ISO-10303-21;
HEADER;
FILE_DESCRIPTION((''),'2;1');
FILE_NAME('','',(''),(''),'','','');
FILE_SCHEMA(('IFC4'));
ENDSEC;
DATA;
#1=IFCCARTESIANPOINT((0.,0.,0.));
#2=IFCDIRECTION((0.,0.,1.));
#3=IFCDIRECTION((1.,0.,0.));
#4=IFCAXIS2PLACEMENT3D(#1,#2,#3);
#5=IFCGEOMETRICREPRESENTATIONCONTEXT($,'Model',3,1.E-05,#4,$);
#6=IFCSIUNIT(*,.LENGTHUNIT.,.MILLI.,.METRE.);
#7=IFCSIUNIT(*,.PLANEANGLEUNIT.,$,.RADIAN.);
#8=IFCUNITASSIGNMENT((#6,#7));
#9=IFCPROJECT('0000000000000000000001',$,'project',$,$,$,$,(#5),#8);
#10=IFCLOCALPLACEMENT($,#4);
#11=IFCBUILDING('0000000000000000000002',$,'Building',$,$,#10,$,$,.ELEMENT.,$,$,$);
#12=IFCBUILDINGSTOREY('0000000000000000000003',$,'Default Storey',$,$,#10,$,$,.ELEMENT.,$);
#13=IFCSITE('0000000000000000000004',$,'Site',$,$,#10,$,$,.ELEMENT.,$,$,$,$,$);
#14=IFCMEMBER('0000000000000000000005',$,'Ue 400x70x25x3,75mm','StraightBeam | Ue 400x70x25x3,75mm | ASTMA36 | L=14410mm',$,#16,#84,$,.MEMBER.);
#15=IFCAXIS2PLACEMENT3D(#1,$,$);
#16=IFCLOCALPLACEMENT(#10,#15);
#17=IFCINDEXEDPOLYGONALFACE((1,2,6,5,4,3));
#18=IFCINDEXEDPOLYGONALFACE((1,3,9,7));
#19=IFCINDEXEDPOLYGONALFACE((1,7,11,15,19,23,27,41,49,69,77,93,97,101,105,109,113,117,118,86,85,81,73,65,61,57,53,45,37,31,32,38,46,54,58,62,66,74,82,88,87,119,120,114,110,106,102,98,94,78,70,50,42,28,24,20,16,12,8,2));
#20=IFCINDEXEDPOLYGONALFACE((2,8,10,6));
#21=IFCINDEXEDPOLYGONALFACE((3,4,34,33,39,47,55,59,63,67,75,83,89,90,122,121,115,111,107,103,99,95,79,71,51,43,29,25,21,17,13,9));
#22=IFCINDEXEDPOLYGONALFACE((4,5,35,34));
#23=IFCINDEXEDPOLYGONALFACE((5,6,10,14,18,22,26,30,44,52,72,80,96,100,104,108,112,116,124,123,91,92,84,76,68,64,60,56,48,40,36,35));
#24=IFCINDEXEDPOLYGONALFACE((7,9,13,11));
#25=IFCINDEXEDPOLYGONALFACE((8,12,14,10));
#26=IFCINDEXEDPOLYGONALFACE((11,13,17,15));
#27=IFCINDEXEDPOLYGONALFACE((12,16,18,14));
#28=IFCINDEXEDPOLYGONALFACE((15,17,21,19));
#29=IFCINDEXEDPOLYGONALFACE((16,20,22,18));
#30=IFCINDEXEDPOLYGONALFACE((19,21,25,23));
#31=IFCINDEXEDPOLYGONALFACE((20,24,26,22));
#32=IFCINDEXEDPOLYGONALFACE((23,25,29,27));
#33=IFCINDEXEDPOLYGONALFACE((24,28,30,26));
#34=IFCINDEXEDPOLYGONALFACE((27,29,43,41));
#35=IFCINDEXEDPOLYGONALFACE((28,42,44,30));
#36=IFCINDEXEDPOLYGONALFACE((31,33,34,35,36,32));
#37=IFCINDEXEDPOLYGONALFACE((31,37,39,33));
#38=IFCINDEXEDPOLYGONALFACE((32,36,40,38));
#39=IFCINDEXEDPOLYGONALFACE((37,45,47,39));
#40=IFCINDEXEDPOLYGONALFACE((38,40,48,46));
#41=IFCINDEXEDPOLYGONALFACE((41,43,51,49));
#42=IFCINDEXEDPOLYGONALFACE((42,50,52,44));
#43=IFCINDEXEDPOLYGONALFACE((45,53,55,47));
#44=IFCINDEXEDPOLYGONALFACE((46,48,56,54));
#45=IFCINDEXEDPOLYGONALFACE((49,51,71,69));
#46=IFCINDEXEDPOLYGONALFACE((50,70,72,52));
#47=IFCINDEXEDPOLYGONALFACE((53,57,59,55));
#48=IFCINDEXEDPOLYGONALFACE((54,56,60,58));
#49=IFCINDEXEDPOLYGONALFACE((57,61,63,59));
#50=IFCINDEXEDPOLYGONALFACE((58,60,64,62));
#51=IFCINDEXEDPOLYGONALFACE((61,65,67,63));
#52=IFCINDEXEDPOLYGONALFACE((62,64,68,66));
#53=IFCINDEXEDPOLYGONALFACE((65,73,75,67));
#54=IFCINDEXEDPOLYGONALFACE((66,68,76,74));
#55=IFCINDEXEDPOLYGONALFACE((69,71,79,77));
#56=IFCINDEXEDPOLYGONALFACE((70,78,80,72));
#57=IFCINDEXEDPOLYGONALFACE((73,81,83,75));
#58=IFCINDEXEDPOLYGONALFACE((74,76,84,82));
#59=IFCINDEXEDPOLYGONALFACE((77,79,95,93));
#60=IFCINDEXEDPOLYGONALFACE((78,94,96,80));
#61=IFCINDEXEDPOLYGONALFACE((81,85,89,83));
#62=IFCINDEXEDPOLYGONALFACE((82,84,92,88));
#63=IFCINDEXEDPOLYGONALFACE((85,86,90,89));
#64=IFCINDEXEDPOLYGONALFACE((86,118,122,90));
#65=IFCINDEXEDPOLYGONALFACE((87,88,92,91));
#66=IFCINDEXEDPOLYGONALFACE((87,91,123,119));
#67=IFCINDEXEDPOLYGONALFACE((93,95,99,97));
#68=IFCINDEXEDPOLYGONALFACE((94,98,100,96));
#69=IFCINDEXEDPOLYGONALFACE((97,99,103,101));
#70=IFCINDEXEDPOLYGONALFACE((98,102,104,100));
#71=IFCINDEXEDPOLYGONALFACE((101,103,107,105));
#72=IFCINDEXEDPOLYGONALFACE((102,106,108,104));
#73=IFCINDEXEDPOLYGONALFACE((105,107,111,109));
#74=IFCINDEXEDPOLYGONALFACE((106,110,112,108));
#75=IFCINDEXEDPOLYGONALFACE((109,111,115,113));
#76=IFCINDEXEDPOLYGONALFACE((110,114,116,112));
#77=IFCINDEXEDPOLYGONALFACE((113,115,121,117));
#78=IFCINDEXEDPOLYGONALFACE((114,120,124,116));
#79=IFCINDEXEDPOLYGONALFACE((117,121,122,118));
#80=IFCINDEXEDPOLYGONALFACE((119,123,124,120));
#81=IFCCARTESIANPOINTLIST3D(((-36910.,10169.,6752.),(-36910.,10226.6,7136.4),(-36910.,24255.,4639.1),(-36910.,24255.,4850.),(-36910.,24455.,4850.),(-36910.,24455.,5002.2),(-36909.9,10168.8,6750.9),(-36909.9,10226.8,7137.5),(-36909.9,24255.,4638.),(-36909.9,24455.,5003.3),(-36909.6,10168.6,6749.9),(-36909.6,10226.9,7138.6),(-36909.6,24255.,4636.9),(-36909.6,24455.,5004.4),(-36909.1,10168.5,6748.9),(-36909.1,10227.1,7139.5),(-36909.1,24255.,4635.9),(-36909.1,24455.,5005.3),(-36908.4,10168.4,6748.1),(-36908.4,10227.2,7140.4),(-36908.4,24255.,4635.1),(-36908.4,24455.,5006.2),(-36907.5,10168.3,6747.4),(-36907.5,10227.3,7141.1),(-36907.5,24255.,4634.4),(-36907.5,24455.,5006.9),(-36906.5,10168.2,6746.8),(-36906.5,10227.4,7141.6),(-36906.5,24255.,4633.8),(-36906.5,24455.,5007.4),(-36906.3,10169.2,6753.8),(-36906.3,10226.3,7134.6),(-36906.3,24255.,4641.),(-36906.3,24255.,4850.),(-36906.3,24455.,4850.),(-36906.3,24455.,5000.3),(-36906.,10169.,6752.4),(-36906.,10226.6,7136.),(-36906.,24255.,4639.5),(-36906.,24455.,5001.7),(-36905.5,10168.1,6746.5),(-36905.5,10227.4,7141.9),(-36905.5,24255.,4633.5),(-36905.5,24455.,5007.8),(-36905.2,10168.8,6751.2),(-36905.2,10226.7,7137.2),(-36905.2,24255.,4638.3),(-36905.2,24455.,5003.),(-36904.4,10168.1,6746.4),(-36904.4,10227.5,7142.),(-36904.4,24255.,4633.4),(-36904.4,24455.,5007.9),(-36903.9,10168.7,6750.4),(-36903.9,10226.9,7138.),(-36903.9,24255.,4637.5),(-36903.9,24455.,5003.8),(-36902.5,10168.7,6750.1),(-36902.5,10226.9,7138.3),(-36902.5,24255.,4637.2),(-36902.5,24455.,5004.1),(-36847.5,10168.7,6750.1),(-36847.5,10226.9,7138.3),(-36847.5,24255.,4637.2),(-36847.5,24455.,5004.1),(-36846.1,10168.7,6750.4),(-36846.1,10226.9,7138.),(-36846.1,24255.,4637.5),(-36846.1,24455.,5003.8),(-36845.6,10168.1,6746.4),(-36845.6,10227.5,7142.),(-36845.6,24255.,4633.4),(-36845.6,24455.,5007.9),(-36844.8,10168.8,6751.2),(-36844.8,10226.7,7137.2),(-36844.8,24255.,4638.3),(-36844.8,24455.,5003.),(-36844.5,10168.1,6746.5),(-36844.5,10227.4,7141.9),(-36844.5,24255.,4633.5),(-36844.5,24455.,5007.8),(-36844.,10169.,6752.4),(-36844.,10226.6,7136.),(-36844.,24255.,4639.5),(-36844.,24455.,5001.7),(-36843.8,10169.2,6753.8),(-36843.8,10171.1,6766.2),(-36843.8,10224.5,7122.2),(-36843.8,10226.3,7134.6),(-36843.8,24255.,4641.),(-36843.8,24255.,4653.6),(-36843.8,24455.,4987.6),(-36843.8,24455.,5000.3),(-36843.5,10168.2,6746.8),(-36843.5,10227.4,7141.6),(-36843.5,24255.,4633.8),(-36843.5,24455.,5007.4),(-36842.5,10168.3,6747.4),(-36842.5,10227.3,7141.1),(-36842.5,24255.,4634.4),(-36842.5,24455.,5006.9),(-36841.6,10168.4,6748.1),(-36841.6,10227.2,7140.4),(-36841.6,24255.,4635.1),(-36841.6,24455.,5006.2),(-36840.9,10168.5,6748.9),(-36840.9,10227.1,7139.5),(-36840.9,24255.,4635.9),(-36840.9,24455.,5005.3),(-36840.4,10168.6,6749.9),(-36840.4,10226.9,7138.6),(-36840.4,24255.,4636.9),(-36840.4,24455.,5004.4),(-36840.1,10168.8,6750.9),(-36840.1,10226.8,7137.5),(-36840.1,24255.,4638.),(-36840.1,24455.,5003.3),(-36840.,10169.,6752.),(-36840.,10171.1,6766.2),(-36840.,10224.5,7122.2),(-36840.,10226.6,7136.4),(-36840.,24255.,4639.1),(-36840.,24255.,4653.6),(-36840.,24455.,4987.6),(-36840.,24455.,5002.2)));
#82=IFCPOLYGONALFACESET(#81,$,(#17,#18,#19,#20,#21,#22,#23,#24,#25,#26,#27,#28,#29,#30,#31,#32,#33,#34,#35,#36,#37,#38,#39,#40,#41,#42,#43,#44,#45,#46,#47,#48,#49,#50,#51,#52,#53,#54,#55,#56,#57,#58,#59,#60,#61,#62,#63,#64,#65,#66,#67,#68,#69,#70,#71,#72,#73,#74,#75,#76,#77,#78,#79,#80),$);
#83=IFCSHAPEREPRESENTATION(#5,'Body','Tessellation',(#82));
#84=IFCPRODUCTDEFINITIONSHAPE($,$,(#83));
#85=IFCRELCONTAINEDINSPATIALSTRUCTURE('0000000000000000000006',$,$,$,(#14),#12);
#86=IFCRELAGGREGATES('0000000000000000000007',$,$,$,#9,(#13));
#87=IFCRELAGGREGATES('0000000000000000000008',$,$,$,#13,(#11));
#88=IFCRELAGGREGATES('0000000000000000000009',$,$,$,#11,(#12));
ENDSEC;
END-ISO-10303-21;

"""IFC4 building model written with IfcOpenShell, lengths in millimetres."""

from ifc_helpers import new_model, si_unit, frame, origin_with_axes, place, context, project, spatial, polyline, outline, extrude, clip, halfspace, element, save


model = new_model("IFC4")

# Units and contexts
model_context = context("Model", 3, precision=1e-05, world=origin_with_axes())
ifc_project = project(units=[si_unit("LENGTHUNIT", "METRE", prefix="MILLI"), si_unit("PLANEANGLEUNIT", "RADIAN")], contexts=[model_context])

# Site, building, storey
placement = place(None, origin_with_axes())
site = spatial("IfcSite", under=ifc_project, at=placement, Name="Site", CompositionType="ELEMENT")
building = spatial("IfcBuilding", under=site, at=placement, Name="Building", CompositionType="ELEMENT")
storey = spatial("IfcBuildingStorey", under=building, at=placement, Name="Default Storey", CompositionType="ELEMENT")

# Member, openings
member_1_placement = place(placement, frame((-36875.0, 10375.8, 6917.5), z_axis=(0.0, -0.988936, 0.14834), x_axis=(1.0, 0.0, 0.0)))
member_1 = element("IfcMember", 1, at=member_1_placement, inside=storey, Name="Ue 400x70x25x3,75mm", Description="StraightBeam | Ue 400x70x25x3,75mm | ASTMA36 | L=14410mm", PredefinedType="MEMBER", context=model_context, shape_type="Clipping", body=[
    clip(extrude(outline(polyline([(35.0, 180.0), (35.0, 194.4), (34.9, 195.5), (34.6, 196.5), (34.1, 197.5), (33.4, 198.4), (32.5, 199.1), (31.5, 199.6), (30.5, 199.9), (29.4, 200.0), (-29.4, 200.0), (-30.5, 199.9), (-31.5, 199.6), (-32.5, 199.1), (-33.4, 198.4), (-34.1, 197.5), (-34.6, 196.5), (-34.9, 195.5), (-35.0, 194.4), (-35.0, -194.4), (-34.9, -195.5), (-34.6, -196.5), (-34.1, -197.5), (-33.4, -198.4), (-32.5, -199.1), (-31.5, -199.6), (-30.5, -199.9), (-29.4, -200.0), (29.4, -200.0), (30.5, -199.9), (31.5, -199.6), (32.5, -199.1), (33.4, -198.4), (34.1, -197.5), (34.6, -196.5), (34.9, -195.5), (35.0, -194.4), (35.0, -180.0), (31.2, -180.0), (31.2, -192.5), (31.0, -193.9), (30.2, -195.2), (28.9, -196.0), (27.5, -196.2), (-27.5, -196.2), (-28.9, -196.0), (-30.2, -195.2), (-31.0, -193.9), (-31.2, -192.5), (-31.2, 192.5), (-31.0, 193.9), (-30.2, 195.2), (-28.9, 196.0), (-27.5, 196.2), (27.5, 196.2), (28.9, 196.0), (30.2, 195.2), (31.0, 193.9), (31.2, 192.5), (31.2, 180.0), (35.0, 180.0)])), frame((0.0, 0.0, 180.0), z_axis=(0.0, 0.0, 1.0), x_axis=(1.0, 0.0, 0.0)), (0.0, 0.0, -1.0), 14410.1), halfspace(frame((36875.0, -8380.1, 180.0), z_axis=(0.0, 0.0, -1.0), x_axis=(-1.0, 0.0, 0.0)), True)),
])
opening_1_placement = place(member_1_placement, frame((-135.1, -108.6, -14169.6), z_axis=(1.0, 0.0, 0.0), x_axis=(0.0, 0.14834, -0.988936)))
element("IfcOpeningElement", 2, at=opening_1_placement, cuts=member_1, PredefinedType="OPENING", context=model_context, shape_type="SweptSolid", body=[
    extrude(outline(polyline([(-117.5, -141.8), (117.5, -141.8), (117.5, 141.8), (-117.5, 141.8), (-117.5, -141.8)])), origin_with_axes(), (0.0, 0.0, 1.0), 270.2),
])
opening_2_placement = place(member_1_placement, frame((-135.1, 126.6, -14237.1), z_axis=(1.0, 0.0, 0.0), x_axis=(0.0, 0.14834, -0.988936)))
element("IfcOpeningElement", 3, at=opening_2_placement, cuts=member_1, PredefinedType="OPENING", context=model_context, shape_type="SweptSolid", body=[
    extrude(outline(polyline([(-19.2, -80.8), (19.2, -80.8), (19.2, 80.8), (-19.2, 80.8), (-19.2, -80.8)])), origin_with_axes(), (0.0, 0.0, 1.0), 270.2),
])

save(model, "model.ifc")
